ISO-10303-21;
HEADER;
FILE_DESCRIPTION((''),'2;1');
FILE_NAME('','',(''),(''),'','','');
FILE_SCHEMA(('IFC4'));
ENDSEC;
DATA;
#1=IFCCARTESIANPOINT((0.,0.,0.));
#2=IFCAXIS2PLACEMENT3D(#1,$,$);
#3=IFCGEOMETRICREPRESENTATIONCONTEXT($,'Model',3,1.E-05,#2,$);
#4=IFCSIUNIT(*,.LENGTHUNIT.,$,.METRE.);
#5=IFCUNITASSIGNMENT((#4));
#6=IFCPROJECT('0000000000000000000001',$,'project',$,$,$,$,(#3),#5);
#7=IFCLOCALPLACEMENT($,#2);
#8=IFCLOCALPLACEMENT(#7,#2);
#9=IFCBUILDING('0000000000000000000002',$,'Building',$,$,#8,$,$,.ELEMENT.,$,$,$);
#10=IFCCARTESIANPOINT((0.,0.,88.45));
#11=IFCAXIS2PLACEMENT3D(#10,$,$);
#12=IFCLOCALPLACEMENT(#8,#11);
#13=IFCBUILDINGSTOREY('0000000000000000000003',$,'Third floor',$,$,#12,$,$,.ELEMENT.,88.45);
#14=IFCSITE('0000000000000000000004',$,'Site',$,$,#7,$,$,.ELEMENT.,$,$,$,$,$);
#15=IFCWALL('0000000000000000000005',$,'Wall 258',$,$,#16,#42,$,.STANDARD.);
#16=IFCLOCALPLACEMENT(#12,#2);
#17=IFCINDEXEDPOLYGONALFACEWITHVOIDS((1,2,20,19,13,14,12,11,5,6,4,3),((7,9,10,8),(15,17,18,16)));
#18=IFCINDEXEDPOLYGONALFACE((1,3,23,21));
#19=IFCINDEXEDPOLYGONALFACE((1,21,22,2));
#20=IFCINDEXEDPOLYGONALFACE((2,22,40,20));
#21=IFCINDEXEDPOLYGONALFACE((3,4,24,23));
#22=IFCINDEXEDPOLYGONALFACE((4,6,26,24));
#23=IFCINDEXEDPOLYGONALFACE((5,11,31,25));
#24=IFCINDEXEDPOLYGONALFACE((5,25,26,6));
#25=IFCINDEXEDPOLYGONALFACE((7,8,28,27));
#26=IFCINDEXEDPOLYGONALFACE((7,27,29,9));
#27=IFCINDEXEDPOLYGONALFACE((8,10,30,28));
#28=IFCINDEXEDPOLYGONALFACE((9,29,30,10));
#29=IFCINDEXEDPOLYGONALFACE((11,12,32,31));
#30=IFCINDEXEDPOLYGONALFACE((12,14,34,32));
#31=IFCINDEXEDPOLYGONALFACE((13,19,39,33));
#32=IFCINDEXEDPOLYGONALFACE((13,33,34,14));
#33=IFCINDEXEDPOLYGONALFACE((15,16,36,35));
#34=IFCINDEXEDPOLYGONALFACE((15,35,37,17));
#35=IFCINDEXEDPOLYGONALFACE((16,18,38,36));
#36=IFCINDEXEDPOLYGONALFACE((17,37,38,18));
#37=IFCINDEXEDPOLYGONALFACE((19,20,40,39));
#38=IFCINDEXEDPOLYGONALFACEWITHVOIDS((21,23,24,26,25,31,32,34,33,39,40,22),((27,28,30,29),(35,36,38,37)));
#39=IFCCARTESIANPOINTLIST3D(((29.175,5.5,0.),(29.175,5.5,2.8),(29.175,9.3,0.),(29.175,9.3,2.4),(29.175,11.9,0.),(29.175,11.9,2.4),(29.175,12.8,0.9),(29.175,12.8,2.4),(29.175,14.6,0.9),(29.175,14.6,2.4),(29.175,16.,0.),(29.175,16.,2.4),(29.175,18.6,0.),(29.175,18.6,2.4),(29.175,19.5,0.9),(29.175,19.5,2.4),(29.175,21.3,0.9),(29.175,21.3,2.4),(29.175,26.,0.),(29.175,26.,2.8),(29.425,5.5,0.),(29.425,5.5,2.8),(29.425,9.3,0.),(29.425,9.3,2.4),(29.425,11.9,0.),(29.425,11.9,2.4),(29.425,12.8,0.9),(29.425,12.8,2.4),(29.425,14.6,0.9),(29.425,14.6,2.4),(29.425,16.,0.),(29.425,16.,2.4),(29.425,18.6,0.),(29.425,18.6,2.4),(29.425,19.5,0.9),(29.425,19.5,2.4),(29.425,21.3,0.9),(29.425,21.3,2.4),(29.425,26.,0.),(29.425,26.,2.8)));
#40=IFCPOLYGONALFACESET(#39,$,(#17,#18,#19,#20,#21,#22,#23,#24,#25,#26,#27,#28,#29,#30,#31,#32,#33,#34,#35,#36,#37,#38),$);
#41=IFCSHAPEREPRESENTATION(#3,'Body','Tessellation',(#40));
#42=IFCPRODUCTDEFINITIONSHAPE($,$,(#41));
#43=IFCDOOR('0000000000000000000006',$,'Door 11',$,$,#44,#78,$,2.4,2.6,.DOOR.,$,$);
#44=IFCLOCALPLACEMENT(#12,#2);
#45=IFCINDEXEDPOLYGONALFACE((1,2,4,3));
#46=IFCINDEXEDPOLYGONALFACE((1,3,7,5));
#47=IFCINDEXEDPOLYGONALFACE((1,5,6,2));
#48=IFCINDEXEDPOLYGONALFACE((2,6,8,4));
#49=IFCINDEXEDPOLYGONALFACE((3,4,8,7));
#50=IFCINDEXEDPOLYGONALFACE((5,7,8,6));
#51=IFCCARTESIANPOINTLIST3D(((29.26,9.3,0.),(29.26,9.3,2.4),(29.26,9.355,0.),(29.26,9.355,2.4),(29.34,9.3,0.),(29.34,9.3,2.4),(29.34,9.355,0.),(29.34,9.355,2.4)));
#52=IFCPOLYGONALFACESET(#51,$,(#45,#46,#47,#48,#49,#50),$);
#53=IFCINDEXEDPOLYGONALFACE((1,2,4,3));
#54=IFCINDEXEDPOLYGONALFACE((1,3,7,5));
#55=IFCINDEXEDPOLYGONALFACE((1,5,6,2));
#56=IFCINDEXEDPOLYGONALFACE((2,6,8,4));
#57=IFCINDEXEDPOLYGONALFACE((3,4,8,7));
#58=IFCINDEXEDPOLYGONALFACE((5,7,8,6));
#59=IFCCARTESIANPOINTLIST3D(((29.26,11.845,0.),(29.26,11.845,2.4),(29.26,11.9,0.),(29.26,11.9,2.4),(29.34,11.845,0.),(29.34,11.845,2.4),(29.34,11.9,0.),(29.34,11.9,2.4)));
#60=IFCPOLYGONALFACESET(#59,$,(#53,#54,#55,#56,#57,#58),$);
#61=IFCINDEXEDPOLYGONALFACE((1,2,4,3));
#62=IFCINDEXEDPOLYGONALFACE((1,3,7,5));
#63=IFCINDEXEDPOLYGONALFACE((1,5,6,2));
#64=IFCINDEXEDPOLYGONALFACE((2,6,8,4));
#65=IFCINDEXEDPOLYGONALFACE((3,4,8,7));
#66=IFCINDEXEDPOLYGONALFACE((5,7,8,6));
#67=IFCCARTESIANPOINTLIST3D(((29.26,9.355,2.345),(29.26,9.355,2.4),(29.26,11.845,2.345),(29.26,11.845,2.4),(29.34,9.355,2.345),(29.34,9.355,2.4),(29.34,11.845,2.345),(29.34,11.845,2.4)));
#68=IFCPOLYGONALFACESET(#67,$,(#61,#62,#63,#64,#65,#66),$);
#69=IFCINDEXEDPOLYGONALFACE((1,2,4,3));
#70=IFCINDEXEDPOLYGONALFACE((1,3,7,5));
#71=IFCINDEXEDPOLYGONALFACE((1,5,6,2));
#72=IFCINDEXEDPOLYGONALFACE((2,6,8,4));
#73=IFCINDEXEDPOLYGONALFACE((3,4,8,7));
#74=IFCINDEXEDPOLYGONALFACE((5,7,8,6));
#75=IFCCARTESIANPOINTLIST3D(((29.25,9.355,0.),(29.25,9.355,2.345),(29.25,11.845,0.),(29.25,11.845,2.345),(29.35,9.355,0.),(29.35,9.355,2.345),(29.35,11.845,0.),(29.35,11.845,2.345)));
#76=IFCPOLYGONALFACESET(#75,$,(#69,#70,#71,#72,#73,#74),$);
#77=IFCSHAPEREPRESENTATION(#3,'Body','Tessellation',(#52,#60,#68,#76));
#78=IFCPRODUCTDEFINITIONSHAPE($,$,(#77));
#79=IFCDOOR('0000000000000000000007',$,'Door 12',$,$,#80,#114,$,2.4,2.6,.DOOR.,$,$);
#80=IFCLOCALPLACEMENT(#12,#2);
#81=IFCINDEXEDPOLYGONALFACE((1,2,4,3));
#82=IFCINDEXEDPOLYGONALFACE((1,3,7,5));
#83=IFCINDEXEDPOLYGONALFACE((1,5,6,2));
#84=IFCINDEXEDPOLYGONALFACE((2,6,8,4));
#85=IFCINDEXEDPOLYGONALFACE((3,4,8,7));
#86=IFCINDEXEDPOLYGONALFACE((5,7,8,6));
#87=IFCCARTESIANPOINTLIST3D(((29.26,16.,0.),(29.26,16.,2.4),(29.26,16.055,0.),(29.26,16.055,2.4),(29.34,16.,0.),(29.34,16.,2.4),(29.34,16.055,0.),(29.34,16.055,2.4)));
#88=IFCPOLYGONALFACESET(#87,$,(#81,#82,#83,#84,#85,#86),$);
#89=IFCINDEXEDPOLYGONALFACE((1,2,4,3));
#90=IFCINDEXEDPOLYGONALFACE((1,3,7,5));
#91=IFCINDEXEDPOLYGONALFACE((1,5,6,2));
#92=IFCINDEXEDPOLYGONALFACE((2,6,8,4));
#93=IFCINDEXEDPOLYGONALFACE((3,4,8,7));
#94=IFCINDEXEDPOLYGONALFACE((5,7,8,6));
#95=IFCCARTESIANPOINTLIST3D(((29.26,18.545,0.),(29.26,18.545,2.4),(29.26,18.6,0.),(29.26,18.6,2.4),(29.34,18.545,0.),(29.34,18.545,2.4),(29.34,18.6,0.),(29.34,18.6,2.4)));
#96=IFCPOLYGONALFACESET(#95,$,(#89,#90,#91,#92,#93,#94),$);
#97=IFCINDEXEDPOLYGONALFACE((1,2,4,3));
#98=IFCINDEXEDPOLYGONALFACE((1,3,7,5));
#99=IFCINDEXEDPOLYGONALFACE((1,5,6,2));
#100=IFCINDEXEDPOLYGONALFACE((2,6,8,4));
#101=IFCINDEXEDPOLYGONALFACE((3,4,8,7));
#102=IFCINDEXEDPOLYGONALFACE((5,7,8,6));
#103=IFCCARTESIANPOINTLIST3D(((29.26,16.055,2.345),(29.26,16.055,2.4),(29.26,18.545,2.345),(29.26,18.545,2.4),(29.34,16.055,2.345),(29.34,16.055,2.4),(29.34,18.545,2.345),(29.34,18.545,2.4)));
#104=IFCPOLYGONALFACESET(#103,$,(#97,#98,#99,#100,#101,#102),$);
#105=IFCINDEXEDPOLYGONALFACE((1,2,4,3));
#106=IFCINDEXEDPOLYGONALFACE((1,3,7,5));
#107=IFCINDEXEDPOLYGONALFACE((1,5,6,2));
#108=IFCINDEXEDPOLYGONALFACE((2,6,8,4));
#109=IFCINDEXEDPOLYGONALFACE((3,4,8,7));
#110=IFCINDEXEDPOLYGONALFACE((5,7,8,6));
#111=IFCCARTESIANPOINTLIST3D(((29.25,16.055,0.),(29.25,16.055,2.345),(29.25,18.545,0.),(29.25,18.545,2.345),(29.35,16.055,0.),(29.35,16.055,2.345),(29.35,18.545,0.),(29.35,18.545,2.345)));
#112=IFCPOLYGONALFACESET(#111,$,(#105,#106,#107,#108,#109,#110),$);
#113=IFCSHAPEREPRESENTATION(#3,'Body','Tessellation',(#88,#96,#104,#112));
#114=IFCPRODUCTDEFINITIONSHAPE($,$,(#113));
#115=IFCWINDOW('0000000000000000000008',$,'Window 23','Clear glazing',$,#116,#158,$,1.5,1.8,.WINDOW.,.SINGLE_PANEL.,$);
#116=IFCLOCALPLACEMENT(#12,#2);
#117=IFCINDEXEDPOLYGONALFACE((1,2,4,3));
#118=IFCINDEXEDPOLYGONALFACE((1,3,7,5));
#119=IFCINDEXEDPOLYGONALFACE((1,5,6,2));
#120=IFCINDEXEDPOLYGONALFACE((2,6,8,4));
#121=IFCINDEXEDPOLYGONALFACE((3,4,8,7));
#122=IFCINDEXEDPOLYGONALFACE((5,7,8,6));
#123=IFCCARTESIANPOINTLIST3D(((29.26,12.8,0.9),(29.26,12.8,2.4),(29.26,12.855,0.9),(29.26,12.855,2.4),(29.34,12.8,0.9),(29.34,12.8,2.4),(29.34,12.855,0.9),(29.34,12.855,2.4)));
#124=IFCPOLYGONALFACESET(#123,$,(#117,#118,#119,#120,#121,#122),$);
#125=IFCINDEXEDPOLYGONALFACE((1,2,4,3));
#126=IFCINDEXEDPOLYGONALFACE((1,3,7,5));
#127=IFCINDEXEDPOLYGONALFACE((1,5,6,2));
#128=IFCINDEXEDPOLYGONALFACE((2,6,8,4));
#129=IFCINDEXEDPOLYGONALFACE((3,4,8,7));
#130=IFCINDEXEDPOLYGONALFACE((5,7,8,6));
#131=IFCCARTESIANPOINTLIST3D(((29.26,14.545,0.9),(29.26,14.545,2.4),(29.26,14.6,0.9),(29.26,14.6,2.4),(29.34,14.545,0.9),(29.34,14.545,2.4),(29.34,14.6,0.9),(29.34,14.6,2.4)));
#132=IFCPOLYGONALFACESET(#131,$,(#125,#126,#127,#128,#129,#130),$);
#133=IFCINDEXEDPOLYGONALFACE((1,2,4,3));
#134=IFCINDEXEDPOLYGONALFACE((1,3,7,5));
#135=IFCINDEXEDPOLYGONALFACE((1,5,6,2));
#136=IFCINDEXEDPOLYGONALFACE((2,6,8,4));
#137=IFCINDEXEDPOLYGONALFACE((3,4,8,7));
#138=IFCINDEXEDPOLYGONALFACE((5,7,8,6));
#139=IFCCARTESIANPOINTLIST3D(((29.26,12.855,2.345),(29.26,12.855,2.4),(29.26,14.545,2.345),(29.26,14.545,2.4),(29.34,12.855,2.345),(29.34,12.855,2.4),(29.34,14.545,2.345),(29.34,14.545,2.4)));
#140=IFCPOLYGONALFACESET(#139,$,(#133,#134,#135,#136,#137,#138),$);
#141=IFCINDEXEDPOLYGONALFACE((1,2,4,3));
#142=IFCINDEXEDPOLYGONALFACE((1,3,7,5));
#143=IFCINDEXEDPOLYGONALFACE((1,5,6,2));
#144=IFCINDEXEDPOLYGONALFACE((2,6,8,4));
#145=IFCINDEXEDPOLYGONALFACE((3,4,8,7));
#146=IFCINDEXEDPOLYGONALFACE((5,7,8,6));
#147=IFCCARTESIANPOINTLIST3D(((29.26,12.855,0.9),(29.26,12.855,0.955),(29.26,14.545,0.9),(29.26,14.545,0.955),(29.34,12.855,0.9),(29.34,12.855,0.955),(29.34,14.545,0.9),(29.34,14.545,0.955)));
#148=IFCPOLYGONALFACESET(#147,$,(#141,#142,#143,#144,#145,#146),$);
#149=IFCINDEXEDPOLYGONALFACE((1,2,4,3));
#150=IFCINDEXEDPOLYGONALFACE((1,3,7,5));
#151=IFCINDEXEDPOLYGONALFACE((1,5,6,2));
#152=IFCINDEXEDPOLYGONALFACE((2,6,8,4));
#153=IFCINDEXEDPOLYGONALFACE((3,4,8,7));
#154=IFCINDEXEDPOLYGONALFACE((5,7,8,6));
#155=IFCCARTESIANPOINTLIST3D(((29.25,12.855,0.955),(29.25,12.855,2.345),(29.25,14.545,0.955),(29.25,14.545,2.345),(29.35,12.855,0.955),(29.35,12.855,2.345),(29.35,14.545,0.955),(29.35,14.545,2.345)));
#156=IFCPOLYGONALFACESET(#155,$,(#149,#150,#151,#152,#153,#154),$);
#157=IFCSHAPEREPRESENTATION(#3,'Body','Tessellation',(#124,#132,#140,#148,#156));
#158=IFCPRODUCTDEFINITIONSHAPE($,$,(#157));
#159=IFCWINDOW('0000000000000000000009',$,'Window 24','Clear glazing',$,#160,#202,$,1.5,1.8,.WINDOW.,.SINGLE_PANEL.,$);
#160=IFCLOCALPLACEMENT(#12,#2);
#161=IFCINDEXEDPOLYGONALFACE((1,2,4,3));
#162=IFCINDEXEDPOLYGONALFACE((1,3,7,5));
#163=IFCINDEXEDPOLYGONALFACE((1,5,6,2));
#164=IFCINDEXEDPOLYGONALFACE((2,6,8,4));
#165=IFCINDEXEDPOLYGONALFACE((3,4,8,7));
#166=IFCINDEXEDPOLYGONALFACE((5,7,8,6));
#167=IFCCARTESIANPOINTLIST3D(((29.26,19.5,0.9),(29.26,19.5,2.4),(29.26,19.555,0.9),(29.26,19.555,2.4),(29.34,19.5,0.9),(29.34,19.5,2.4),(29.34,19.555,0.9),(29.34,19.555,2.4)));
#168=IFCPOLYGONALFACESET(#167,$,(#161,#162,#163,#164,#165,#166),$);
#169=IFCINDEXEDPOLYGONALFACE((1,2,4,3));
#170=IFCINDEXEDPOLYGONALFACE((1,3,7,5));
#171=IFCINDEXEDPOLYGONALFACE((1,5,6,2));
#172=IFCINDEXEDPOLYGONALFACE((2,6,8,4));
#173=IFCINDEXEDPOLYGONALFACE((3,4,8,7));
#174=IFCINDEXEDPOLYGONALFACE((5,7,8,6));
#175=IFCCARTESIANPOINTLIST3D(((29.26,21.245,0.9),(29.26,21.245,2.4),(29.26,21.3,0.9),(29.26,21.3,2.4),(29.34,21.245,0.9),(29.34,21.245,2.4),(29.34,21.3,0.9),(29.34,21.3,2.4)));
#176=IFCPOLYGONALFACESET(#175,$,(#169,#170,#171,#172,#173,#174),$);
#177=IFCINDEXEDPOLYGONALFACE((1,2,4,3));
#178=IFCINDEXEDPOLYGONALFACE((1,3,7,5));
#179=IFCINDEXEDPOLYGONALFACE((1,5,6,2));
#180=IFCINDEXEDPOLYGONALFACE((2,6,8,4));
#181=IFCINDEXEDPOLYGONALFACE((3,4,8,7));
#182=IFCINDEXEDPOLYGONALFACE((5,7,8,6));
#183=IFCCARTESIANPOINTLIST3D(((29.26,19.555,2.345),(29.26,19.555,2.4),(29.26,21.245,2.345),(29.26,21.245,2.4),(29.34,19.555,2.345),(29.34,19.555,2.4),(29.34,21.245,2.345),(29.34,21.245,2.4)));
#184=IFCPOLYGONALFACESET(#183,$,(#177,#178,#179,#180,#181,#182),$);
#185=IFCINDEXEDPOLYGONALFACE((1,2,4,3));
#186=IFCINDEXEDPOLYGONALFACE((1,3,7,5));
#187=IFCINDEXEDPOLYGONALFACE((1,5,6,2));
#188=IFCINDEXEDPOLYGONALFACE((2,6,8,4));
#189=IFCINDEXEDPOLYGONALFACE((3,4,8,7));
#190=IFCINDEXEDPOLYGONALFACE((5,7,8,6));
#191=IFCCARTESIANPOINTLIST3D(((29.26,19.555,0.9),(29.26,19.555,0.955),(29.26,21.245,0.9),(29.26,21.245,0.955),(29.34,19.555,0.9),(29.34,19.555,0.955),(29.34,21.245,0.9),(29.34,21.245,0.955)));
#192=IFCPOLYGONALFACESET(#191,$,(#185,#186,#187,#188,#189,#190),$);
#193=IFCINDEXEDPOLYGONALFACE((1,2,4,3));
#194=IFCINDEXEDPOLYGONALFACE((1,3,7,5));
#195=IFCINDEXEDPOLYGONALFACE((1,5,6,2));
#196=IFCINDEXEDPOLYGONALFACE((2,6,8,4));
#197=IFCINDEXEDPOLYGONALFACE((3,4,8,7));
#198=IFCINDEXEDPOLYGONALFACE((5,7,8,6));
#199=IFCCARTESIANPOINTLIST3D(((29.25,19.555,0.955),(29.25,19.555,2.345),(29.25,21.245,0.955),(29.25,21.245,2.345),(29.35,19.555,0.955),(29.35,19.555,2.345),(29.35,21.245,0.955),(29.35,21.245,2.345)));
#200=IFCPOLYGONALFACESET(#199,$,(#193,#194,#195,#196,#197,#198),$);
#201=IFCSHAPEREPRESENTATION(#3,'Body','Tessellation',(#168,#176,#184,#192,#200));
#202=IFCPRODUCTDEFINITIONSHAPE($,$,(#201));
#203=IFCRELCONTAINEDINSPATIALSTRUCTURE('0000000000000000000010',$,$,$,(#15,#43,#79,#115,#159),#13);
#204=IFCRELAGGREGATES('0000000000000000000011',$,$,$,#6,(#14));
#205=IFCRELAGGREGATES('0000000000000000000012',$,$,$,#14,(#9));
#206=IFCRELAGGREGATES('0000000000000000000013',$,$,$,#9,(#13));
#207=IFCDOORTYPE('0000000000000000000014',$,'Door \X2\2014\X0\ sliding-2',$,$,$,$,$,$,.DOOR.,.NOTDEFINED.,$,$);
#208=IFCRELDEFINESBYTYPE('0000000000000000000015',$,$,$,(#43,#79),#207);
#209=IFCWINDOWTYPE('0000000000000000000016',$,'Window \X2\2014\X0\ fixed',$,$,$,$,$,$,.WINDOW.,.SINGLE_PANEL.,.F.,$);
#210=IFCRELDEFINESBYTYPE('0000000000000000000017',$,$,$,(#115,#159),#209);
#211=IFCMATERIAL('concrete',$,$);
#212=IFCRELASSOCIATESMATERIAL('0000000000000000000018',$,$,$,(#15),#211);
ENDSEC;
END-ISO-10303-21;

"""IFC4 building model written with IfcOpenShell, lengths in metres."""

from ifc_helpers import new_model, si_unit, frame, frame_2d, origin, place, context, project, spatial, rectangle, extrude, material, type_object, element, fill, save


model = new_model("IFC4")

# Units and contexts
model_context = context("Model", 3, precision=1e-05, world=origin())
ifc_project = project(units=[si_unit("LENGTHUNIT", "METRE")], contexts=[model_context])

# Site, building, storey
site_placement = place(None, origin())
site = spatial("IfcSite", under=ifc_project, at=site_placement, Name="Site", CompositionType="ELEMENT")
building_placement = place(site_placement, origin())
building = spatial("IfcBuilding", under=site, at=building_placement, Name="Building", CompositionType="ELEMENT")
storey_placement = place(building_placement, frame((0.0, 0.0, 88.45)))
storey = spatial("IfcBuildingStorey", under=building, at=storey_placement, Name="Third floor", CompositionType="ELEMENT", Elevation=88.45)

# Shared definitions
ifc_material = material(Name="concrete")

# Wall, openings, doors, windows
wall_1_placement = place(storey_placement, frame((29.3, 5.5, 0.0), z_axis=(0.0, 0.0, 1.0), x_axis=(0.0, 1.0, 0.0)))
wall_1 = element("IfcWall", 1, at=wall_1_placement, inside=storey, material=ifc_material, Name="Wall 258", PredefinedType="STANDARD", context=model_context, shape_type="SweptSolid", body=[
    extrude(rectangle(XDim=20.5, YDim=0.25, at=frame_2d((10.25, 0.0))), origin(), (0.0, 0.0, 1.0), 2.8),
])
opening_1_placement = place(storey_placement, frame((29.3, 9.3, 0.0), z_axis=(0.0, 0.0, 1.0), x_axis=(0.0, 1.0, 0.0)))
opening_1 = element("IfcOpeningElement", 2, at=opening_1_placement, cuts=wall_1, PredefinedType="OPENING", context=model_context, shape_type="SweptSolid", body=[
    extrude(rectangle(XDim=2.6, YDim=0.31, at=frame_2d((1.3, 0.0))), origin(), (0.0, 0.0, 1.0), 2.4),
])
opening_2_placement = place(storey_placement, frame((29.3, 12.8, 0.9), z_axis=(0.0, 0.0, 1.0), x_axis=(0.0, 1.0, 0.0)))
opening_2 = element("IfcOpeningElement", 3, at=opening_2_placement, cuts=wall_1, PredefinedType="OPENING", context=model_context, shape_type="SweptSolid", body=[
    extrude(rectangle(XDim=1.8, YDim=0.31, at=frame_2d((0.9, 0.0))), origin(), (0.0, 0.0, 1.0), 1.5),
])
opening_3_placement = place(storey_placement, frame((29.3, 16.0, 0.0), z_axis=(0.0, 0.0, 1.0), x_axis=(0.0, 1.0, 0.0)))
opening_3 = element("IfcOpeningElement", 4, at=opening_3_placement, cuts=wall_1, PredefinedType="OPENING", context=model_context, shape_type="SweptSolid", body=[
    extrude(rectangle(XDim=2.6, YDim=0.31, at=frame_2d((1.3, 0.0))), origin(), (0.0, 0.0, 1.0), 2.4),
])
opening_4_placement = place(storey_placement, frame((29.3, 19.5, 0.9), z_axis=(0.0, 0.0, 1.0), x_axis=(0.0, 1.0, 0.0)))
opening_4 = element("IfcOpeningElement", 5, at=opening_4_placement, cuts=wall_1, PredefinedType="OPENING", context=model_context, shape_type="SweptSolid", body=[
    extrude(rectangle(XDim=1.8, YDim=0.31, at=frame_2d((0.9, 0.0))), origin(), (0.0, 0.0, 1.0), 1.5),
])
door_type = type_object("IfcDoorType", Name="Door — sliding-2", PredefinedType="DOOR")
door_1_placement = place(storey_placement, frame((29.3, 9.3, 0.0), z_axis=(0.0, 0.0, 1.0), x_axis=(0.0, 1.0, 0.0)))
door_1 = element("IfcDoor", 6, at=door_1_placement, inside=storey, type_object=door_type, Name="Door 11", OverallHeight=2.4, OverallWidth=2.6, PredefinedType="DOOR", context=model_context, shape_type="SweptSolid", body=[
    extrude(rectangle(XDim=0.055, YDim=0.08, at=frame_2d((0.0275, 0.0))), origin(), (0.0, 0.0, 1.0), 2.4),
    extrude(rectangle(XDim=0.055, YDim=0.08, at=frame_2d((2.5725, 0.0))), origin(), (0.0, 0.0, 1.0), 2.4),
    extrude(rectangle(XDim=2.49, YDim=0.08, at=frame_2d((1.3, 0.0))), frame((0.0, 0.0, 2.345)), (0.0, 0.0, 1.0), 0.055),
    extrude(rectangle(XDim=2.49, YDim=0.1, at=frame_2d((1.3, 0.0))), origin(), (0.0, 0.0, 1.0), 2.345),
])
fill(opening_1, door_1)
door_2_placement = place(storey_placement, frame((29.3, 16.0, 0.0), z_axis=(0.0, 0.0, 1.0), x_axis=(0.0, 1.0, 0.0)))
door_2 = element("IfcDoor", 7, at=door_2_placement, inside=storey, type_object=door_type, Name="Door 12", OverallHeight=2.4, OverallWidth=2.6, PredefinedType="DOOR", context=model_context, shape_type="SweptSolid", body=[
    extrude(rectangle(XDim=0.055, YDim=0.08, at=frame_2d((0.0275, 0.0))), origin(), (0.0, 0.0, 1.0), 2.4),
    extrude(rectangle(XDim=0.055, YDim=0.08, at=frame_2d((2.5725, 0.0))), origin(), (0.0, 0.0, 1.0), 2.4),
    extrude(rectangle(XDim=2.49, YDim=0.08, at=frame_2d((1.3, 0.0))), frame((0.0, 0.0, 2.345)), (0.0, 0.0, 1.0), 0.055),
    extrude(rectangle(XDim=2.49, YDim=0.1, at=frame_2d((1.3, 0.0))), origin(), (0.0, 0.0, 1.0), 2.345),
])
fill(opening_3, door_2)
window_type = type_object("IfcWindowType", Name="Window — fixed", ParameterTakesPrecedence=False, PartitioningType="SINGLE_PANEL", PredefinedType="WINDOW")
window_1_placement = place(storey_placement, frame((29.3, 12.8, 0.9), z_axis=(0.0, 0.0, 1.0), x_axis=(0.0, 1.0, 0.0)))
window_1 = element("IfcWindow", 8, at=window_1_placement, inside=storey, type_object=window_type, Name="Window 23", Description="Clear glazing", OverallHeight=1.5, OverallWidth=1.8, PartitioningType="SINGLE_PANEL", PredefinedType="WINDOW", context=model_context, shape_type="SweptSolid", body=[
    extrude(rectangle(XDim=0.055, YDim=0.08, at=frame_2d((0.0275, 0.0))), origin(), (0.0, 0.0, 1.0), 1.5),
    extrude(rectangle(XDim=0.055, YDim=0.08, at=frame_2d((1.7725, 0.0))), origin(), (0.0, 0.0, 1.0), 1.5),
    extrude(rectangle(XDim=1.69, YDim=0.08, at=frame_2d((0.9, 0.0))), frame((0.0, 0.0, 1.445)), (0.0, 0.0, 1.0), 0.055),
    extrude(rectangle(XDim=1.69, YDim=0.08, at=frame_2d((0.9, 0.0))), origin(), (0.0, 0.0, 1.0), 0.055),
    extrude(rectangle(XDim=1.69, YDim=0.1, at=frame_2d((0.9, 0.0))), frame((0.0, 0.0, 0.055)), (0.0, 0.0, 1.0), 1.39),
])
fill(opening_2, window_1)
window_2_placement = place(storey_placement, frame((29.3, 19.5, 0.9), z_axis=(0.0, 0.0, 1.0), x_axis=(0.0, 1.0, 0.0)))
window_2 = element("IfcWindow", 9, at=window_2_placement, inside=storey, type_object=window_type, Name="Window 24", Description="Clear glazing", OverallHeight=1.5, OverallWidth=1.8, PartitioningType="SINGLE_PANEL", PredefinedType="WINDOW", context=model_context, shape_type="SweptSolid", body=[
    extrude(rectangle(XDim=0.055, YDim=0.08, at=frame_2d((0.0275, 0.0))), origin(), (0.0, 0.0, 1.0), 1.5),
    extrude(rectangle(XDim=0.055, YDim=0.08, at=frame_2d((1.7725, 0.0))), origin(), (0.0, 0.0, 1.0), 1.5),
    extrude(rectangle(XDim=1.69, YDim=0.08, at=frame_2d((0.9, 0.0))), frame((0.0, 0.0, 1.445)), (0.0, 0.0, 1.0), 0.055),
    extrude(rectangle(XDim=1.69, YDim=0.08, at=frame_2d((0.9, 0.0))), origin(), (0.0, 0.0, 1.0), 0.055),
    extrude(rectangle(XDim=1.69, YDim=0.1, at=frame_2d((0.9, 0.0))), frame((0.0, 0.0, 0.055)), (0.0, 0.0, 1.0), 1.39),
])
fill(opening_4, window_2)

save(model, "model.ifc")
